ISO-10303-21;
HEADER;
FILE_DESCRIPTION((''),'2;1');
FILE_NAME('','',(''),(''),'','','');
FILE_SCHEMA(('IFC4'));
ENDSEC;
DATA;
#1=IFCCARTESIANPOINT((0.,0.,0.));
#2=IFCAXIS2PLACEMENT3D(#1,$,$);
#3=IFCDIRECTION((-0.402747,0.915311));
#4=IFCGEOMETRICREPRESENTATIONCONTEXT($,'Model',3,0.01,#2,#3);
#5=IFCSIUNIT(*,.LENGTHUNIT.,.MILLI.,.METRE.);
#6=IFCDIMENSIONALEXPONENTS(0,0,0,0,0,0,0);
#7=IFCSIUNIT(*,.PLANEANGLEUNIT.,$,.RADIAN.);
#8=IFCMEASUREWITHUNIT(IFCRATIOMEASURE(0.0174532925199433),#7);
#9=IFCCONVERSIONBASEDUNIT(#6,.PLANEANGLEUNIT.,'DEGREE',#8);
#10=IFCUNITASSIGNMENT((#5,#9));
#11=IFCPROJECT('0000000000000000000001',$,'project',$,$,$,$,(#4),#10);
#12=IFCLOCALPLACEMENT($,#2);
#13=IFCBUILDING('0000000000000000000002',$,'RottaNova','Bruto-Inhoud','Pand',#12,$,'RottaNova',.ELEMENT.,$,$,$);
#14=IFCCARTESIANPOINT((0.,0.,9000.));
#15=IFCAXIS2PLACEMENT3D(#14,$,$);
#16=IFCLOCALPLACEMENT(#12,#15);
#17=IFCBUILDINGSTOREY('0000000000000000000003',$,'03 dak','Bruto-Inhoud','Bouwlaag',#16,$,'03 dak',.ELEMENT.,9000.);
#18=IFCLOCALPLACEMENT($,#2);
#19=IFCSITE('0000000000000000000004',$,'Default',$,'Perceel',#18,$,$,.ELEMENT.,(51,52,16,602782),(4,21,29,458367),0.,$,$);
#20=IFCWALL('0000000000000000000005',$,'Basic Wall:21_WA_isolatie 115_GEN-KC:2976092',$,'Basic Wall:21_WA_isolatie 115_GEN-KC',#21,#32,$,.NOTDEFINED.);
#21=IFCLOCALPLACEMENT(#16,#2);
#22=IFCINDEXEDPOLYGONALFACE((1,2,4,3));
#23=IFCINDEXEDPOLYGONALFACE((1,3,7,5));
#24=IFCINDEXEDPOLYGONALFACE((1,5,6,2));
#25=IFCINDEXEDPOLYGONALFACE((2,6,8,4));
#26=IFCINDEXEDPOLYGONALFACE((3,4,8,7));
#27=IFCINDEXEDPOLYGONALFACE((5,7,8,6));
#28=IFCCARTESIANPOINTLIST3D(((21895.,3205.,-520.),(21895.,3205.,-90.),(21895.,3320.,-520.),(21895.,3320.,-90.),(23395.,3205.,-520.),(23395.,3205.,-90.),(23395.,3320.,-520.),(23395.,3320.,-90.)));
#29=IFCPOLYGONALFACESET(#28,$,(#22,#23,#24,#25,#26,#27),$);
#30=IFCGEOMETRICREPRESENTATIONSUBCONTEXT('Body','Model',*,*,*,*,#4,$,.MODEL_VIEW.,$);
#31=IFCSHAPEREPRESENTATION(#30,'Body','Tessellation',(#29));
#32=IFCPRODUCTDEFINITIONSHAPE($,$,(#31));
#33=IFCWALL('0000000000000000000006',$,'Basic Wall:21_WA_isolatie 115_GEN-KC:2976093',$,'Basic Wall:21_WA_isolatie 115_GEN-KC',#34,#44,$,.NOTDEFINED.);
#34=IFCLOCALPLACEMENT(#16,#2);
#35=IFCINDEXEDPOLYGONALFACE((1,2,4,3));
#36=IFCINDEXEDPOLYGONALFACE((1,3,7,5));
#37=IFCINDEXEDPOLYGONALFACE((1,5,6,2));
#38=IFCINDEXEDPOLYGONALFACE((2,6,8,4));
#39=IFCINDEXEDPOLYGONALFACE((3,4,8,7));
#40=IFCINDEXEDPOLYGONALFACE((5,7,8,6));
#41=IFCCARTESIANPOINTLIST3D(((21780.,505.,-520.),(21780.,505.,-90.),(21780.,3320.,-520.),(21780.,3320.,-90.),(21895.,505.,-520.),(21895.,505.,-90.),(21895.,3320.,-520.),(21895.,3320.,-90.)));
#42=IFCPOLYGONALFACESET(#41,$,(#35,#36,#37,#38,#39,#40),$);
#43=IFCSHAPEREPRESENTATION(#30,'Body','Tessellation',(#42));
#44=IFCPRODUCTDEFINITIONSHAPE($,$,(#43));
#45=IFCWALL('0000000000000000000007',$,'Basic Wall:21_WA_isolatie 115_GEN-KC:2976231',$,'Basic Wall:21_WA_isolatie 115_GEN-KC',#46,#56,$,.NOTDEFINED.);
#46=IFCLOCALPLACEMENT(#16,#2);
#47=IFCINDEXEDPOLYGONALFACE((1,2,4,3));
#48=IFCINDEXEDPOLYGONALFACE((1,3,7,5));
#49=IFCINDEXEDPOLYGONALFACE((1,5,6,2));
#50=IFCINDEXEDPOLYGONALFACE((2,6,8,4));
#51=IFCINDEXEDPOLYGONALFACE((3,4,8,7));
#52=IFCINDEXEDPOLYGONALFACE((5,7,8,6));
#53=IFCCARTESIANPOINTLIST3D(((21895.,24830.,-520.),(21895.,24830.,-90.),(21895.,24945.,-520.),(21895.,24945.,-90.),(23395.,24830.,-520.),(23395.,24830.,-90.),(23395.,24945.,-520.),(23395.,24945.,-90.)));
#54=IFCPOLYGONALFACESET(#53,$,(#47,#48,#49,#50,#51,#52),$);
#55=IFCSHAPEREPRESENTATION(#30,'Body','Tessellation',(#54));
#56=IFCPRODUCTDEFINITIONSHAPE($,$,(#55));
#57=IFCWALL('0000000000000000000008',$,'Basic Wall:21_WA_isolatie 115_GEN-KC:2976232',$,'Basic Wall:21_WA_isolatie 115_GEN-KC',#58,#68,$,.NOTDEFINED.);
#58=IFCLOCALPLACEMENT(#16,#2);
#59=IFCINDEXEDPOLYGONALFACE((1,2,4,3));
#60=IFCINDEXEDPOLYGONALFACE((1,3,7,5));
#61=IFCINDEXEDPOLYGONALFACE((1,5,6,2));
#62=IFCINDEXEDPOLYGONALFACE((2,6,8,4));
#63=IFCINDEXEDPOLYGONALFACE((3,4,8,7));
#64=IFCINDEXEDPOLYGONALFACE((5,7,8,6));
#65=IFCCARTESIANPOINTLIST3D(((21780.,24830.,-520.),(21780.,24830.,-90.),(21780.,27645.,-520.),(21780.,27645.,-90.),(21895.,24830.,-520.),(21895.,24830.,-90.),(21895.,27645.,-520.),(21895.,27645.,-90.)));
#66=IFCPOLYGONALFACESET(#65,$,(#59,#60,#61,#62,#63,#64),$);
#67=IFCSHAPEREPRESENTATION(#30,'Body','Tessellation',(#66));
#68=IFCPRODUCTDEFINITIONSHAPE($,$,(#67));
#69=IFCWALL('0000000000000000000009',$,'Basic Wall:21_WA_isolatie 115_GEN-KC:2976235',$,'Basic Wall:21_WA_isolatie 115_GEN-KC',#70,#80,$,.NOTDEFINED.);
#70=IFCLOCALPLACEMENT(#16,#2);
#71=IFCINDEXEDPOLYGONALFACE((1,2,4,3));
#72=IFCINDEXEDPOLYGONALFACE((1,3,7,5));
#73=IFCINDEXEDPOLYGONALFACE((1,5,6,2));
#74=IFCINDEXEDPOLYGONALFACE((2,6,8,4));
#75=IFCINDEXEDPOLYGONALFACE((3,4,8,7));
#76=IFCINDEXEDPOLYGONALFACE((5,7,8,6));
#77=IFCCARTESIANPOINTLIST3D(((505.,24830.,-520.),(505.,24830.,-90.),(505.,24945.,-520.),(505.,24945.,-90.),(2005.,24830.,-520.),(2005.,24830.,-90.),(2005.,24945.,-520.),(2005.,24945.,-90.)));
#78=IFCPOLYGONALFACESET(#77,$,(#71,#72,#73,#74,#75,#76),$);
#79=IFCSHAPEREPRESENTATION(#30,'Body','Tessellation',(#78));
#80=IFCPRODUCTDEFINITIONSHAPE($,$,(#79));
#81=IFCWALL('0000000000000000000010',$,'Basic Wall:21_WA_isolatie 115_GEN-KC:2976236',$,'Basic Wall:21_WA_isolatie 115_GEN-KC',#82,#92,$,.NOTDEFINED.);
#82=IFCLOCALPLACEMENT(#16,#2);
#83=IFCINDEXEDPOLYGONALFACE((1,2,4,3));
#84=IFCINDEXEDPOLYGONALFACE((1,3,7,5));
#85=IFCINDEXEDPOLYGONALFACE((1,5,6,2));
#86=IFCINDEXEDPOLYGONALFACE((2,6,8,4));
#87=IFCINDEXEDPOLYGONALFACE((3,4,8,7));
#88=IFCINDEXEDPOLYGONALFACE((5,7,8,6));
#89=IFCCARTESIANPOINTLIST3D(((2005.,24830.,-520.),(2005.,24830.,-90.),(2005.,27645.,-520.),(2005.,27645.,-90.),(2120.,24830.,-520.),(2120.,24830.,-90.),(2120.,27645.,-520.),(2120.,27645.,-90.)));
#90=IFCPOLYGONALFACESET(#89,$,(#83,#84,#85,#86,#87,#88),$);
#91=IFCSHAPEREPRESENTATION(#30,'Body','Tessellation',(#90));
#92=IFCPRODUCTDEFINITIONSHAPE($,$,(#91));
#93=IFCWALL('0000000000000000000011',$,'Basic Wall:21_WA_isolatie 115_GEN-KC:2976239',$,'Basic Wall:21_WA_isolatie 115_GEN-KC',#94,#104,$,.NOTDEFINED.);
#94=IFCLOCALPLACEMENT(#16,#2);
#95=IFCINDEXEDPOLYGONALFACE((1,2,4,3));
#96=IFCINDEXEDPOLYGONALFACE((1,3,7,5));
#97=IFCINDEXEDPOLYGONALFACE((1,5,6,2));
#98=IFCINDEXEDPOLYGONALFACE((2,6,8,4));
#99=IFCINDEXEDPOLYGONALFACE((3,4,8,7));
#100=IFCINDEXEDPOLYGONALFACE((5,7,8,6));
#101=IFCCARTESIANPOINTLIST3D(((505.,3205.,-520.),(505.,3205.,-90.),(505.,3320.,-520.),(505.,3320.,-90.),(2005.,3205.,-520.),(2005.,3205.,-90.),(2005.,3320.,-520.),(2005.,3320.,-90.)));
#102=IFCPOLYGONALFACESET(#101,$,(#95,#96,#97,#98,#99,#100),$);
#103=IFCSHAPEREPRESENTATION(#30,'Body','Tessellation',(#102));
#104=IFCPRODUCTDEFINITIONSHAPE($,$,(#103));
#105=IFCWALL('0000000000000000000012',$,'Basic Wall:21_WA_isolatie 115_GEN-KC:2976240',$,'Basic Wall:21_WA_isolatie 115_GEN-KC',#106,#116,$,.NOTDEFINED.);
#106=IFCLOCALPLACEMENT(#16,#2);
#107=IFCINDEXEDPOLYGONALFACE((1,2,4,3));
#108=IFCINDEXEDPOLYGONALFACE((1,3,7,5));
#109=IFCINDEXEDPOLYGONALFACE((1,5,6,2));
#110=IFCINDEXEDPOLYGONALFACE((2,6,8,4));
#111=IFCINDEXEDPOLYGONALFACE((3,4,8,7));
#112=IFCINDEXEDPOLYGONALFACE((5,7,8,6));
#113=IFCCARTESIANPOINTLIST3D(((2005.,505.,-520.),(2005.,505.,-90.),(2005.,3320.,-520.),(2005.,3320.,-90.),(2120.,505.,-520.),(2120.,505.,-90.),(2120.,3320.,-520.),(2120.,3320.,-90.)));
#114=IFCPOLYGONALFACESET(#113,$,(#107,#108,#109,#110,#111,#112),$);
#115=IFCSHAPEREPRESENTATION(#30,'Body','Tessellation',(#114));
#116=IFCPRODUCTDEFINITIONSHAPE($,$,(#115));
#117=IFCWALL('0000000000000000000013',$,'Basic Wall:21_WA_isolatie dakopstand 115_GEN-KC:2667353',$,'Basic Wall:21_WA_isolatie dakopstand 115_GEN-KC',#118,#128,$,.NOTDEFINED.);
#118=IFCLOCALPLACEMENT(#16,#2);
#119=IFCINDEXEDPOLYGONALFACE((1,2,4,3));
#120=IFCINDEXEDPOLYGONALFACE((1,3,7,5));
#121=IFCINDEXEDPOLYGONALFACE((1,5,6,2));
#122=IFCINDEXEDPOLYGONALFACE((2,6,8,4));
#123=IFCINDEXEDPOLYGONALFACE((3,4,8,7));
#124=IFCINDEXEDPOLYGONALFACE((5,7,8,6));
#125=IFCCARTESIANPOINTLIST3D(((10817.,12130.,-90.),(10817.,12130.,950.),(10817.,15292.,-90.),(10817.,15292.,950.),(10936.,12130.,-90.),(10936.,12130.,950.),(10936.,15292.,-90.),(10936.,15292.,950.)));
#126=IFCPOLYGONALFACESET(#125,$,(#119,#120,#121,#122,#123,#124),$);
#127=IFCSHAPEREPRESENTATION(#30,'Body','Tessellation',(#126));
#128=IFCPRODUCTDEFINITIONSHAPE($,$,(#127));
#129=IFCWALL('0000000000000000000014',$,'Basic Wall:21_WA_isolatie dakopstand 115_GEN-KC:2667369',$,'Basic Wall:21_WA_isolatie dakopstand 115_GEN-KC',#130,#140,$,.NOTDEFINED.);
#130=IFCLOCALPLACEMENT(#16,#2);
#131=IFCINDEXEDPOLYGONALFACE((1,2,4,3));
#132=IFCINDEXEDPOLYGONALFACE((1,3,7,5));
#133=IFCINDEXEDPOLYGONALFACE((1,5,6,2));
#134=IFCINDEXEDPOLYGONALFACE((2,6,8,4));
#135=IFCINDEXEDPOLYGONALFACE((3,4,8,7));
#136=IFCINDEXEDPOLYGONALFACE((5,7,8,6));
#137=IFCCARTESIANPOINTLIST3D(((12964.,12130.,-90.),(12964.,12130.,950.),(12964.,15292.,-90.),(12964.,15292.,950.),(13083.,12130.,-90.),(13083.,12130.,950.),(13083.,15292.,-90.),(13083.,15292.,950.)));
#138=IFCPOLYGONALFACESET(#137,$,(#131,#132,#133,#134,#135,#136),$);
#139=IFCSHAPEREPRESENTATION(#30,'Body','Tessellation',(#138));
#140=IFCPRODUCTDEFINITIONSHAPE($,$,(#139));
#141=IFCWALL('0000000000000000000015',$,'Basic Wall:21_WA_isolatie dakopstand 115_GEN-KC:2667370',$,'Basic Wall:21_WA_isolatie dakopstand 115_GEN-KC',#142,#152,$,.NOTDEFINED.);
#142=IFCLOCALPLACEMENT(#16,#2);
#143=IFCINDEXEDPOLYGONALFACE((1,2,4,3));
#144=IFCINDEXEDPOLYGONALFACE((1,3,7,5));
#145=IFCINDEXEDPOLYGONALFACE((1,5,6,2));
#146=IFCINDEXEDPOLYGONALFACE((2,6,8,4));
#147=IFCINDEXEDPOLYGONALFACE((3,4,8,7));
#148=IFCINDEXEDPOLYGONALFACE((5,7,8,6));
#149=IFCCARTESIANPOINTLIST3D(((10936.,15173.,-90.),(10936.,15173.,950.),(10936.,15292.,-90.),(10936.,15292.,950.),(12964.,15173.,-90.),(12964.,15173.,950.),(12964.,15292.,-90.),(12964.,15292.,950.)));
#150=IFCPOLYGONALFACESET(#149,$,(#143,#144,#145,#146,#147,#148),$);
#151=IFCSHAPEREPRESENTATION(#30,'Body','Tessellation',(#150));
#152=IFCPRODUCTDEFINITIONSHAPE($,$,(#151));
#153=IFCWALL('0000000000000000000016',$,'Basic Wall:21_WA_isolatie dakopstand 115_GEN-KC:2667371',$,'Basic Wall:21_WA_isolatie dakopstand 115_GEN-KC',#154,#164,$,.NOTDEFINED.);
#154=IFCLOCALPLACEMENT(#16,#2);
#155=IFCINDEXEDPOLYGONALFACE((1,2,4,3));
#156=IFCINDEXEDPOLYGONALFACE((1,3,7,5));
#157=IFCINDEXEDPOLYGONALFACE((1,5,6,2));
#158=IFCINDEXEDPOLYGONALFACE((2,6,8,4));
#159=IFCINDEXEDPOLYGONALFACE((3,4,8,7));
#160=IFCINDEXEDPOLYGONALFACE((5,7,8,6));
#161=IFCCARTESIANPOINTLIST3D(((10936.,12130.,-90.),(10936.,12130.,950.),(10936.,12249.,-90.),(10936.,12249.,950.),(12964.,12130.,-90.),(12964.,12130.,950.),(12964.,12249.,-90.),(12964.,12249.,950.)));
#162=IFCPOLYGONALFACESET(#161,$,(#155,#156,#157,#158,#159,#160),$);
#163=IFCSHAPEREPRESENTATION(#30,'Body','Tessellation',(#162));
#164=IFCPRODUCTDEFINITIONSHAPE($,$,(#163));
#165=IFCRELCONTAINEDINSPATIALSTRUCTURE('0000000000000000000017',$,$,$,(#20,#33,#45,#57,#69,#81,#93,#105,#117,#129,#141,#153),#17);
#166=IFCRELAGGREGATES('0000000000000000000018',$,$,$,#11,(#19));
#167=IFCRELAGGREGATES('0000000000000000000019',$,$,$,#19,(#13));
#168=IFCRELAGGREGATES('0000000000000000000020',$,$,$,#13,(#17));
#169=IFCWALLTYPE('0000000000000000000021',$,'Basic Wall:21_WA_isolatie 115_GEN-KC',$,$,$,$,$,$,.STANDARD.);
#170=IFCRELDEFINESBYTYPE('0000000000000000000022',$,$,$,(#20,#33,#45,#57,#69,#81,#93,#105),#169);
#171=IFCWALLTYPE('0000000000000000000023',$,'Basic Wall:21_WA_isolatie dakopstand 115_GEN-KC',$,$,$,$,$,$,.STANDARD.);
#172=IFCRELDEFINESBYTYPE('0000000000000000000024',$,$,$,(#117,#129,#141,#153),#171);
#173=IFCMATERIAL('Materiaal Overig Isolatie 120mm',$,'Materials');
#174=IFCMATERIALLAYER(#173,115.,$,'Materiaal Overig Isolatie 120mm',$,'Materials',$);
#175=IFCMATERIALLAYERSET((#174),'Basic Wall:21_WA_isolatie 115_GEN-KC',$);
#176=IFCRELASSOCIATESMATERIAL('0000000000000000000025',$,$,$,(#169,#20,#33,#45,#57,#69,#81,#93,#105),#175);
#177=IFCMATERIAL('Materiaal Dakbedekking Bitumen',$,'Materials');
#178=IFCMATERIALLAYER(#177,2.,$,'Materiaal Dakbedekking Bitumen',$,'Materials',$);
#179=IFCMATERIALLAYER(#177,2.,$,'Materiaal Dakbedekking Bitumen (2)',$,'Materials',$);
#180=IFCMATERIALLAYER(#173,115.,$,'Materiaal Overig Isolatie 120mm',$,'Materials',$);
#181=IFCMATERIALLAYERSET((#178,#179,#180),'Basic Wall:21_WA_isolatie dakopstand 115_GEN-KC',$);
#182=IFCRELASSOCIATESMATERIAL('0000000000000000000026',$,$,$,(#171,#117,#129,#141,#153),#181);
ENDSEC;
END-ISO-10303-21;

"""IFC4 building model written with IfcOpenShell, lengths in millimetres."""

from ifc_helpers import new_model, entity, si_unit, converted_unit, direction, frame, frame_2d, origin, place, context, subcontext, project, spatial, rectangle, extrude, material, layer, layer_set, type_object, element, save


model = new_model("IFC4")

# Units and contexts
model_context = context("Model", 3, precision=0.01, world=origin(), true_north=direction((-0.402747, 0.915311)))
body_context = subcontext(model_context, "Body", "Model", "MODEL_VIEW")
ifc_project = project(units=[si_unit("LENGTHUNIT", "METRE", prefix="MILLI"), converted_unit("PLANEANGLEUNIT", "DEGREE", entity("IfcRatioMeasure", 0.0174532925199433), si_unit("PLANEANGLEUNIT", "RADIAN"), dimensions=[0, 0, 0, 0, 0, 0, 0])], contexts=[model_context])

# Site, building, storey
site_placement = place(None, origin())
site = spatial("IfcSite", under=ifc_project, at=site_placement, Name="Default", ObjectType="Perceel", CompositionType="ELEMENT", RefLatitude=(51, 52, 16, 602782), RefLongitude=(4, 21, 29, 458367), RefElevation=0.0)
building_placement = place(None, origin())
building = spatial("IfcBuilding", under=site, at=building_placement, Name="RottaNova", Description="Bruto-Inhoud", ObjectType="Pand", LongName="RottaNova", CompositionType="ELEMENT")
storey_placement = place(building_placement, frame((0.0, 0.0, 9000.0)))
storey = spatial("IfcBuildingStorey", under=building, at=storey_placement, Name="03 dak", Description="Bruto-Inhoud", ObjectType="Bouwlaag", LongName="03 dak", CompositionType="ELEMENT", Elevation=9000.0)

# Walls
ifc_material_1 = material(Name="Materiaal Overig Isolatie 120mm", Category="Materials")
ifc_layer_1 = layer(ifc_material_1, 115.0, Name="Materiaal Overig Isolatie 120mm", Category="Materials")
ifc_layer_set_1 = layer_set([ifc_layer_1], Name="Basic Wall:21_WA_isolatie 115_GEN-KC")
wall_type_1 = type_object("IfcWallType", Name="Basic Wall:21_WA_isolatie 115_GEN-KC", PredefinedType="STANDARD", material=ifc_layer_set_1)
wall_1_placement = place(storey_placement, frame((23395.0, 3262.5, -520.0), z_axis=(0.0, 0.0, 1.0), x_axis=(-1.0, 0.0, 0.0)))
element("IfcWall", 1, at=wall_1_placement, inside=storey, type_object=wall_type_1, material=ifc_layer_set_1, Name="Basic Wall:21_WA_isolatie 115_GEN-KC:2976092", ObjectType="Basic Wall:21_WA_isolatie 115_GEN-KC", PredefinedType="NOTDEFINED", context=body_context, shape_type="SweptSolid", body=[
    extrude(rectangle(XDim=1500.0, YDim=115.0, at=frame_2d((750.0, 0.0), x_axis=(-1.0, 0.0))), origin(), (0.0, 0.0, 1.0), 430.0),
])
wall_2_placement = place(storey_placement, frame((21837.5, 3320.0, -520.0), z_axis=(0.0, 0.0, 1.0), x_axis=(0.0, -1.0, 0.0)))
element("IfcWall", 2, at=wall_2_placement, inside=storey, type_object=wall_type_1, material=ifc_layer_set_1, Name="Basic Wall:21_WA_isolatie 115_GEN-KC:2976093", ObjectType="Basic Wall:21_WA_isolatie 115_GEN-KC", PredefinedType="NOTDEFINED", context=body_context, shape_type="SweptSolid", body=[
    extrude(rectangle(XDim=2815.0, YDim=115.0, at=frame_2d((1407.5, 0.0), x_axis=(-1.0, 0.0))), origin(), (0.0, 0.0, 1.0), 430.0),
])
wall_3_placement = place(storey_placement, frame((23395.0, 24887.5, -520.0), z_axis=(0.0, 0.0, 1.0), x_axis=(-1.0, 0.0, 0.0)))
element("IfcWall", 3, at=wall_3_placement, inside=storey, type_object=wall_type_1, material=ifc_layer_set_1, Name="Basic Wall:21_WA_isolatie 115_GEN-KC:2976231", ObjectType="Basic Wall:21_WA_isolatie 115_GEN-KC", PredefinedType="NOTDEFINED", context=body_context, shape_type="SweptSolid", body=[
    extrude(rectangle(XDim=1500.0, YDim=115.0, at=frame_2d((750.0, 0.0), x_axis=(1.0, 0.0))), origin(), (0.0, 0.0, 1.0), 430.0),
])
wall_4_placement = place(storey_placement, frame((21837.5, 24830.0, -520.0), z_axis=(0.0, 0.0, 1.0), x_axis=(0.0, 1.0, 0.0)))
element("IfcWall", 4, at=wall_4_placement, inside=storey, type_object=wall_type_1, material=ifc_layer_set_1, Name="Basic Wall:21_WA_isolatie 115_GEN-KC:2976232", ObjectType="Basic Wall:21_WA_isolatie 115_GEN-KC", PredefinedType="NOTDEFINED", context=body_context, shape_type="SweptSolid", body=[
    extrude(rectangle(XDim=2815.0, YDim=115.0, at=frame_2d((1407.5, 0.0), x_axis=(-1.0, 0.0))), origin(), (0.0, 0.0, 1.0), 430.0),
])
wall_5_placement = place(storey_placement, frame((505.0, 24887.5, -520.0)))
element("IfcWall", 5, at=wall_5_placement, inside=storey, type_object=wall_type_1, material=ifc_layer_set_1, Name="Basic Wall:21_WA_isolatie 115_GEN-KC:2976235", ObjectType="Basic Wall:21_WA_isolatie 115_GEN-KC", PredefinedType="NOTDEFINED", context=body_context, shape_type="SweptSolid", body=[
    extrude(rectangle(XDim=1500.0, YDim=115.0, at=frame_2d((750.0, 0.0), x_axis=(-1.0, 0.0))), origin(), (0.0, 0.0, 1.0), 430.0),
])
wall_6_placement = place(storey_placement, frame((2062.5, 24830.0, -520.0), z_axis=(0.0, 0.0, 1.0), x_axis=(0.0, 1.0, 0.0)))
element("IfcWall", 6, at=wall_6_placement, inside=storey, type_object=wall_type_1, material=ifc_layer_set_1, Name="Basic Wall:21_WA_isolatie 115_GEN-KC:2976236", ObjectType="Basic Wall:21_WA_isolatie 115_GEN-KC", PredefinedType="NOTDEFINED", context=body_context, shape_type="SweptSolid", body=[
    extrude(rectangle(XDim=2815.0, YDim=115.0, at=frame_2d((1407.5, 0.0), x_axis=(-1.0, 0.0))), origin(), (0.0, 0.0, 1.0), 430.0),
])
wall_7_placement = place(storey_placement, frame((505.0, 3262.5, -520.0)))
element("IfcWall", 7, at=wall_7_placement, inside=storey, type_object=wall_type_1, material=ifc_layer_set_1, Name="Basic Wall:21_WA_isolatie 115_GEN-KC:2976239", ObjectType="Basic Wall:21_WA_isolatie 115_GEN-KC", PredefinedType="NOTDEFINED", context=body_context, shape_type="SweptSolid", body=[
    extrude(rectangle(XDim=1500.0, YDim=115.0, at=frame_2d((750.0, 0.0), x_axis=(-1.0, 0.0))), origin(), (0.0, 0.0, 1.0), 430.0),
])
wall_8_placement = place(storey_placement, frame((2062.5, 3320.0, -520.0), z_axis=(0.0, 0.0, 1.0), x_axis=(0.0, -1.0, 0.0)))
element("IfcWall", 8, at=wall_8_placement, inside=storey, type_object=wall_type_1, material=ifc_layer_set_1, Name="Basic Wall:21_WA_isolatie 115_GEN-KC:2976240", ObjectType="Basic Wall:21_WA_isolatie 115_GEN-KC", PredefinedType="NOTDEFINED", context=body_context, shape_type="SweptSolid", body=[
    extrude(rectangle(XDim=2815.0, YDim=115.0, at=frame_2d((1407.5, 0.0), x_axis=(-1.0, 0.0))), origin(), (0.0, 0.0, 1.0), 430.0),
])
ifc_material_2 = material(Name="Materiaal Dakbedekking Bitumen", Category="Materials")
ifc_layer_2 = layer(ifc_material_2, 2.0, Name="Materiaal Dakbedekking Bitumen", Category="Materials")
ifc_layer_3 = layer(ifc_material_2, 2.0, Name="Materiaal Dakbedekking Bitumen (2)", Category="Materials")
ifc_layer_4 = layer(ifc_material_1, 115.0, Name="Materiaal Overig Isolatie 120mm", Category="Materials")
ifc_layer_set_2 = layer_set([ifc_layer_2, ifc_layer_3, ifc_layer_4], Name="Basic Wall:21_WA_isolatie dakopstand 115_GEN-KC")
wall_type_2 = type_object("IfcWallType", Name="Basic Wall:21_WA_isolatie dakopstand 115_GEN-KC", PredefinedType="STANDARD", material=ifc_layer_set_2)
wall_9_placement = place(storey_placement, frame((10876.5, 15292.0, -90.0), z_axis=(0.0, 0.0, 1.0), x_axis=(0.0, -1.0, 0.0)))
element("IfcWall", 9, at=wall_9_placement, inside=storey, type_object=wall_type_2, material=ifc_layer_set_2, Name="Basic Wall:21_WA_isolatie dakopstand 115_GEN-KC:2667353", ObjectType="Basic Wall:21_WA_isolatie dakopstand 115_GEN-KC", PredefinedType="NOTDEFINED", context=body_context, shape_type="SweptSolid", body=[
    extrude(rectangle(XDim=3162.0, YDim=119.0, at=frame_2d((1581.0, 0.0), x_axis=(-1.0, 0.0))), origin(), (0.0, 0.0, 1.0), 1040.0),
])
wall_10_placement = place(storey_placement, frame((13023.5, 15292.0, -90.0), z_axis=(0.0, 0.0, 1.0), x_axis=(0.0, -1.0, 0.0)))
element("IfcWall", 10, at=wall_10_placement, inside=storey, type_object=wall_type_2, material=ifc_layer_set_2, Name="Basic Wall:21_WA_isolatie dakopstand 115_GEN-KC:2667369", ObjectType="Basic Wall:21_WA_isolatie dakopstand 115_GEN-KC", PredefinedType="NOTDEFINED", context=body_context, shape_type="SweptSolid", body=[
    extrude(rectangle(XDim=3162.0, YDim=119.0, at=frame_2d((1581.0, 0.0), x_axis=(-1.0, 0.0))), origin(), (0.0, 0.0, 1.0), 1040.0),
])
wall_11_placement = place(storey_placement, frame((10936.0, 15232.5, -90.0)))
element("IfcWall", 11, at=wall_11_placement, inside=storey, type_object=wall_type_2, material=ifc_layer_set_2, Name="Basic Wall:21_WA_isolatie dakopstand 115_GEN-KC:2667370", ObjectType="Basic Wall:21_WA_isolatie dakopstand 115_GEN-KC", PredefinedType="NOTDEFINED", context=body_context, shape_type="SweptSolid", body=[
    extrude(rectangle(XDim=2028.0, YDim=119.0, at=frame_2d((1014.0, 0.0), x_axis=(-1.0, 0.0))), origin(), (0.0, 0.0, 1.0), 1040.0),
])
wall_12_placement = place(storey_placement, frame((10936.0, 12189.5, -90.0)))
element("IfcWall", 12, at=wall_12_placement, inside=storey, type_object=wall_type_2, material=ifc_layer_set_2, Name="Basic Wall:21_WA_isolatie dakopstand 115_GEN-KC:2667371", ObjectType="Basic Wall:21_WA_isolatie dakopstand 115_GEN-KC", PredefinedType="NOTDEFINED", context=body_context, shape_type="SweptSolid", body=[
    extrude(rectangle(XDim=2028.0, YDim=119.0, at=frame_2d((1014.0, 0.0), x_axis=(-1.0, 0.0))), origin(), (0.0, 0.0, 1.0), 1040.0),
])

save(model, "model.ifc")
